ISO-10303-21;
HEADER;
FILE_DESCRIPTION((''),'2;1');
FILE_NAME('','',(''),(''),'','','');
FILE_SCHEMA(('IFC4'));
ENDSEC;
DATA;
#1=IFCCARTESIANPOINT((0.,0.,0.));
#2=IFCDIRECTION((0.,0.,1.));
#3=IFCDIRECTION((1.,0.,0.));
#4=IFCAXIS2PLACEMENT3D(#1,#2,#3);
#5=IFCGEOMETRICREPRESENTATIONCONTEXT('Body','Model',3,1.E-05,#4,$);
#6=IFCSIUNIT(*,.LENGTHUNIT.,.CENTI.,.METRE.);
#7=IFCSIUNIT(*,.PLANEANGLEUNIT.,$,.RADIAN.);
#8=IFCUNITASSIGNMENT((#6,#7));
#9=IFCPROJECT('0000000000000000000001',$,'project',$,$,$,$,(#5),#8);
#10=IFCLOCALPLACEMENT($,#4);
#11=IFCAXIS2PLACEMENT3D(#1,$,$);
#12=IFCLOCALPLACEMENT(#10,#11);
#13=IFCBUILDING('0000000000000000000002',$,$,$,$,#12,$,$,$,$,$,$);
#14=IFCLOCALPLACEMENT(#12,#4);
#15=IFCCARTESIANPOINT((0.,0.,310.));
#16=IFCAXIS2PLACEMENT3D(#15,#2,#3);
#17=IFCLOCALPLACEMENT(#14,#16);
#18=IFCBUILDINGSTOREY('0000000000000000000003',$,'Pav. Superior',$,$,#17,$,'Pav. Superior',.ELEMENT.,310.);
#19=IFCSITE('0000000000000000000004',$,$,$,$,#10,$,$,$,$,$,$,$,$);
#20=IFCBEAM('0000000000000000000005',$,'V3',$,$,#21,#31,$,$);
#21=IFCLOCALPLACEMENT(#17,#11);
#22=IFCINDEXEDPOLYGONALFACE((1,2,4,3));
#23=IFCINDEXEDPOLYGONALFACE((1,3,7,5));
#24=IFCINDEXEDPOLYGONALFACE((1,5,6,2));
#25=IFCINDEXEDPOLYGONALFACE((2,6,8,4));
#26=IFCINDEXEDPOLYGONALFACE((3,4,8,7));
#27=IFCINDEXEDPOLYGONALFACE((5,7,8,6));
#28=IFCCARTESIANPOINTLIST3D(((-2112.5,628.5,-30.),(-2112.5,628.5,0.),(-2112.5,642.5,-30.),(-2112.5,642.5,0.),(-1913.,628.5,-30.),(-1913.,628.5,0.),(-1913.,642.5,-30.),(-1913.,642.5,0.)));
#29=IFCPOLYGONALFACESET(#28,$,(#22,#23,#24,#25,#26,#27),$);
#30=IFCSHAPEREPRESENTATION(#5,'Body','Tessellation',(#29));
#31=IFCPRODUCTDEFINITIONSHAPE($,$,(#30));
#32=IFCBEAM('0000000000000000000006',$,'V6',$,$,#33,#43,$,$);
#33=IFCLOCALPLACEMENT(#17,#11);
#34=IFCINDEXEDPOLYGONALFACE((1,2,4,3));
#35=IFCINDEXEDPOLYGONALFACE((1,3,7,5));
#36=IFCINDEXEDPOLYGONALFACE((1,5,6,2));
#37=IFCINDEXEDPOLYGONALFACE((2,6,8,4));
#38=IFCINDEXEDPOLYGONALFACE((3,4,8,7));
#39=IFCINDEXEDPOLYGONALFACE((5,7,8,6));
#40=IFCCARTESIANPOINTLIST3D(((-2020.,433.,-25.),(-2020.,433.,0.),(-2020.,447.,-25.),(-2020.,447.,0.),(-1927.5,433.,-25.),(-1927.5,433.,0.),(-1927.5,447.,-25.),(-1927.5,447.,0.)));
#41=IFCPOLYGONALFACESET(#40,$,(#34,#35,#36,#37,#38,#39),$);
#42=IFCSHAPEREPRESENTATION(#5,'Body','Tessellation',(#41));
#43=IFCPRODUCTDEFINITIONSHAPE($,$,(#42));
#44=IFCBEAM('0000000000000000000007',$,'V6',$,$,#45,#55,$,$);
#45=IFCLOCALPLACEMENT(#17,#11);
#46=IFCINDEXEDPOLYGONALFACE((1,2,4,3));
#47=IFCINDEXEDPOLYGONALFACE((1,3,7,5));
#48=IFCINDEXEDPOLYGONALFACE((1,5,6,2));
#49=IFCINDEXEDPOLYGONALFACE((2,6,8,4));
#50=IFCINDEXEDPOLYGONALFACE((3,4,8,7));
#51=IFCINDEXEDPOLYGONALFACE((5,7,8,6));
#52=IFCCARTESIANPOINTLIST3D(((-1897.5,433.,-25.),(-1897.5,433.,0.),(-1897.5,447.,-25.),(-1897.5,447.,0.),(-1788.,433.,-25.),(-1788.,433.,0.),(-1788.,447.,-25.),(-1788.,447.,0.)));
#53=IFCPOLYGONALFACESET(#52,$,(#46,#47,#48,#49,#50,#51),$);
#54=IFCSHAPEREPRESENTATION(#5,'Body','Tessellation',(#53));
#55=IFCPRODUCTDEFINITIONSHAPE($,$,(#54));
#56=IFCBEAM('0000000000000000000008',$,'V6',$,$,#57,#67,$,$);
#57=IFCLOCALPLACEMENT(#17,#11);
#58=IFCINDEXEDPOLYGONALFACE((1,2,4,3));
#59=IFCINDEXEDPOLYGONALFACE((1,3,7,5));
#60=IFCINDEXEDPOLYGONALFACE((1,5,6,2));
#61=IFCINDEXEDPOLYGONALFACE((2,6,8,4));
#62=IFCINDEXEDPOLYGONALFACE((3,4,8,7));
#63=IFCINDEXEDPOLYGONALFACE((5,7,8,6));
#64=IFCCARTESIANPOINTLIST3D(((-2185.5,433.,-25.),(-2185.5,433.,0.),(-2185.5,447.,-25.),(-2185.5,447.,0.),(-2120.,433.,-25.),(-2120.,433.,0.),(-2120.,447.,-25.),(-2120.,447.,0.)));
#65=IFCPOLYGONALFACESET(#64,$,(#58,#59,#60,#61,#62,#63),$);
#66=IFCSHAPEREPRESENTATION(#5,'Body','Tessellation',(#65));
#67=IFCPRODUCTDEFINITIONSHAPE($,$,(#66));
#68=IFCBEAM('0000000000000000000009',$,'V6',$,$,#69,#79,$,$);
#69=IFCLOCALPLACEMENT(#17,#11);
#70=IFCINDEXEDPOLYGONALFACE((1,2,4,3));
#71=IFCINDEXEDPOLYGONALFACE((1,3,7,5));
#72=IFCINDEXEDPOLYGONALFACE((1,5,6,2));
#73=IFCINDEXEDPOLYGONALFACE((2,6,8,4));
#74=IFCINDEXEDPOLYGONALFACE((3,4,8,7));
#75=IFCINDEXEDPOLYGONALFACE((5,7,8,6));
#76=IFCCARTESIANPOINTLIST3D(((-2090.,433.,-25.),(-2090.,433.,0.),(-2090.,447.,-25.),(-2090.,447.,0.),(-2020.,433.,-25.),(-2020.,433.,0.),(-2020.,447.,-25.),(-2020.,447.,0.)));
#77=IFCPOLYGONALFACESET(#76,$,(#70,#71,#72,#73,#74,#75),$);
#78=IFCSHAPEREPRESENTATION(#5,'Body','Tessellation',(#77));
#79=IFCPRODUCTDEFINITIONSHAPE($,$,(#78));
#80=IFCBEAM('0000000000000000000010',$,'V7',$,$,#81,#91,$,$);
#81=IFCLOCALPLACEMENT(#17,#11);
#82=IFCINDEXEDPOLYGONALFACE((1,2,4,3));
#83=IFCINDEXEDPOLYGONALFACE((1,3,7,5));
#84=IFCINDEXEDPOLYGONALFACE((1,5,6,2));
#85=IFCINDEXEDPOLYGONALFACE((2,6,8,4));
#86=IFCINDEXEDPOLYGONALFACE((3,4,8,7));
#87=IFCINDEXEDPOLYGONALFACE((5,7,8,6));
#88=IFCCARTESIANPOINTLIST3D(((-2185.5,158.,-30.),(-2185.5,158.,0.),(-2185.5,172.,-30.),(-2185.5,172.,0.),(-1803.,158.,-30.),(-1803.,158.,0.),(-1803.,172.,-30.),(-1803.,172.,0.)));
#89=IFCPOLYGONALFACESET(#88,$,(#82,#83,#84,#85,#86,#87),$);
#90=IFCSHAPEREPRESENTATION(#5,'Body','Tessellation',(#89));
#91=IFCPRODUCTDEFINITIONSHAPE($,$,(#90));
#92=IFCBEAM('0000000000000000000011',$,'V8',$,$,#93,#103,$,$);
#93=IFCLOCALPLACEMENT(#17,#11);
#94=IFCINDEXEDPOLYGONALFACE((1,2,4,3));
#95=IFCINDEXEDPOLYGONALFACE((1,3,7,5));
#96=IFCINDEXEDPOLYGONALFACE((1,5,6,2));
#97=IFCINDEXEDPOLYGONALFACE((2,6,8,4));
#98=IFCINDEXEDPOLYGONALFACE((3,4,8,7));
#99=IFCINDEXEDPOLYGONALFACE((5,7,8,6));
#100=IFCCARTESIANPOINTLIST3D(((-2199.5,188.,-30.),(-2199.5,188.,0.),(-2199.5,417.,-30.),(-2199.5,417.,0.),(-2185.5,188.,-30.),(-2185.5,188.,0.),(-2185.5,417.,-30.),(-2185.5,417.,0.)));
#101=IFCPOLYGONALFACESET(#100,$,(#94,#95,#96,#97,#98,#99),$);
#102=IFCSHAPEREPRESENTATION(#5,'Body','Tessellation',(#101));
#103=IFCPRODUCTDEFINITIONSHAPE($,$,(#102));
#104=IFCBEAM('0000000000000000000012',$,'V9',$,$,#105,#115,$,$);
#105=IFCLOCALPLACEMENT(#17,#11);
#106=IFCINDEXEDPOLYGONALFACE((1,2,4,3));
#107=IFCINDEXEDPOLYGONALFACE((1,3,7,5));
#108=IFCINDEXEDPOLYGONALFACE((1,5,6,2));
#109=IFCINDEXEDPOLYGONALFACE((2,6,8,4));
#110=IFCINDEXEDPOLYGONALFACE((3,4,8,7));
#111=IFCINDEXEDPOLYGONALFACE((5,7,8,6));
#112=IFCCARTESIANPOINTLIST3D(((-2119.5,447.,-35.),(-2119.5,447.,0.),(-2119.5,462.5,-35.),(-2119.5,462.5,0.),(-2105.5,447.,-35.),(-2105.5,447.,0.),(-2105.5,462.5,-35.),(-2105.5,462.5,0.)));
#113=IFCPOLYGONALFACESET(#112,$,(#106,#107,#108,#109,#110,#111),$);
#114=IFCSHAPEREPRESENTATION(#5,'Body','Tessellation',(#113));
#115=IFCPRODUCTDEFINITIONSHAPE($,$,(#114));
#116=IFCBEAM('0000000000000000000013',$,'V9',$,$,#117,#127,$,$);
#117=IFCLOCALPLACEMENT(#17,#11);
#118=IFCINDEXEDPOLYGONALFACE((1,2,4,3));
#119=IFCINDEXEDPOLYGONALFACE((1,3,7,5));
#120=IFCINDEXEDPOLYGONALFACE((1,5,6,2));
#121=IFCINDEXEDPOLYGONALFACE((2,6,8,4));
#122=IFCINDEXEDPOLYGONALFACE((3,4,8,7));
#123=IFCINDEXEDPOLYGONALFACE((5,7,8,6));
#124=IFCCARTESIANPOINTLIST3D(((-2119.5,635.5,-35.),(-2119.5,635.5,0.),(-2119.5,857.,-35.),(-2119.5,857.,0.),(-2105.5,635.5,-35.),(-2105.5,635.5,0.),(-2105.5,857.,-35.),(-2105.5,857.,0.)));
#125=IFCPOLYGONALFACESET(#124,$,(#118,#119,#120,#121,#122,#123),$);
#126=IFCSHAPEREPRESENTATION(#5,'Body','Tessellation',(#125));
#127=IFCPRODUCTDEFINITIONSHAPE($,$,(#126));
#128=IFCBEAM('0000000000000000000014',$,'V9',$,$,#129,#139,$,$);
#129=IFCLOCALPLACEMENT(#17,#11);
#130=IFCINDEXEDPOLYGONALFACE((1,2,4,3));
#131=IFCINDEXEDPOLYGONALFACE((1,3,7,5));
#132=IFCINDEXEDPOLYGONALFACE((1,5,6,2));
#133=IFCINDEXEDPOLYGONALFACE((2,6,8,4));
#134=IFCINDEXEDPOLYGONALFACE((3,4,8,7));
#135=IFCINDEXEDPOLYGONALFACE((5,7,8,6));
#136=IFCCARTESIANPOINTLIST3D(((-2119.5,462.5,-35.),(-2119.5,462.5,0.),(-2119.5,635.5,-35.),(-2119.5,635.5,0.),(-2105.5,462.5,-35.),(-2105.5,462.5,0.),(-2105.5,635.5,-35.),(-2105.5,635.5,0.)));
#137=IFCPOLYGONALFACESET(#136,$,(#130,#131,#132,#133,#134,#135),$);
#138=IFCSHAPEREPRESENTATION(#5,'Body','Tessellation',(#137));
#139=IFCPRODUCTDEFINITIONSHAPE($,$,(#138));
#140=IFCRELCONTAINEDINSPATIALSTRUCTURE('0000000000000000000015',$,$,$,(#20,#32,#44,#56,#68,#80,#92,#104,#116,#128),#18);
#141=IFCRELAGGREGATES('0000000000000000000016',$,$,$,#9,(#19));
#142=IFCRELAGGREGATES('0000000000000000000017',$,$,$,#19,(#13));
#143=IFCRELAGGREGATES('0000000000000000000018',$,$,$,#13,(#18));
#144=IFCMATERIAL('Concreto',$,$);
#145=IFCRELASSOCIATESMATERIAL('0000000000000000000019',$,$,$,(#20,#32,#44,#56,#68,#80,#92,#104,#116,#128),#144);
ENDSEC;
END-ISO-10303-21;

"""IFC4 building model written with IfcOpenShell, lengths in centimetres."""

from ifc_helpers import new_model, si_unit, frame, origin, origin_with_axes, origin_2d_with_axis, place, context, project, spatial, rectangle, extrude, material, element, save


model = new_model("IFC4")

# Units and contexts
model_context = context("Model", 3, precision=1e-05, world=origin_with_axes(), identifier="Body")
ifc_project = project(units=[si_unit("LENGTHUNIT", "METRE", prefix="CENTI"), si_unit("PLANEANGLEUNIT", "RADIAN")], contexts=[model_context])

# Site, building, storey
site_placement = place(None, origin_with_axes())
site = spatial("IfcSite", under=ifc_project, at=site_placement)
building_placement = place(site_placement, origin())
building = spatial("IfcBuilding", under=site, at=building_placement)
placement = place(building_placement, origin_with_axes())
storey_placement = place(placement, frame((0.0, 0.0, 310.0), z_axis=(0.0, 0.0, 1.0), x_axis=(1.0, 0.0, 0.0)))
storey = spatial("IfcBuildingStorey", under=building, at=storey_placement, Name="Pav. Superior", LongName="Pav. Superior", CompositionType="ELEMENT", Elevation=310.0)

# Shared definitions
ifc_material = material(Name="Concreto")

# Beams
beam_1_placement = place(storey_placement, frame((-2012.75, 635.5, 0.0), z_axis=(0.0, 0.0, 1.0), x_axis=(1.0, 0.0, 0.0)))
element("IfcBeam", 1, at=beam_1_placement, inside=storey, material=ifc_material, Name="V3", context=model_context, shape_type="SolidModel", body=[
    extrude(rectangle(XDim=14.0, YDim=30.0, at=origin_2d_with_axis()), frame((-99.75, 0.0, -15.0), z_axis=(1.0, 0.0, 0.0), x_axis=(0.0, -1.0, 0.0)), (0.0, 0.0, 1.0), 199.5),
])
beam_2_placement = place(storey_placement, frame((-1973.75, 440.0, 0.0), z_axis=(0.0, 0.0, 1.0), x_axis=(1.0, 0.0, 0.0)))
element("IfcBeam", 2, at=beam_2_placement, inside=storey, material=ifc_material, Name="V6", context=model_context, shape_type="SolidModel", body=[
    extrude(rectangle(XDim=14.0, YDim=25.0, at=origin_2d_with_axis()), frame((-46.25, 0.0, -12.5), z_axis=(1.0, 0.0, 0.0), x_axis=(0.0, -1.0, 0.0)), (0.0, 0.0, 1.0), 92.5),
])
beam_3_placement = place(storey_placement, frame((-1842.75, 440.0, 0.0), z_axis=(0.0, 0.0, 1.0), x_axis=(1.0, 0.0, 0.0)))
element("IfcBeam", 3, at=beam_3_placement, inside=storey, material=ifc_material, Name="V6", context=model_context, shape_type="SolidModel", body=[
    extrude(rectangle(XDim=14.0, YDim=25.0, at=origin_2d_with_axis()), frame((-54.75, 0.0, -12.5), z_axis=(1.0, 0.0, 0.0), x_axis=(0.0, -1.0, 0.0)), (0.0, 0.0, 1.0), 109.5),
])
beam_4_placement = place(storey_placement, frame((-2152.75, 440.0, 0.0), z_axis=(0.0, 0.0, 1.0), x_axis=(1.0, 0.0, 0.0)))
element("IfcBeam", 4, at=beam_4_placement, inside=storey, material=ifc_material, Name="V6", context=model_context, shape_type="SolidModel", body=[
    extrude(rectangle(XDim=14.0, YDim=25.0, at=origin_2d_with_axis()), frame((-32.75, 0.0, -12.5), z_axis=(1.0, 0.0, 0.0), x_axis=(0.0, -1.0, 0.0)), (0.0, 0.0, 1.0), 65.5),
])
beam_5_placement = place(storey_placement, frame((-2055.0, 440.0, 0.0), z_axis=(0.0, 0.0, 1.0), x_axis=(1.0, 0.0, 0.0)))
element("IfcBeam", 5, at=beam_5_placement, inside=storey, material=ifc_material, Name="V6", context=model_context, shape_type="SolidModel", body=[
    extrude(rectangle(XDim=14.0, YDim=25.0, at=origin_2d_with_axis()), frame((-35.0, 0.0, -12.5), z_axis=(1.0, 0.0, 0.0), x_axis=(0.0, -1.0, 0.0)), (0.0, 0.0, 1.0), 70.0),
])
beam_6_placement = place(storey_placement, frame((-1994.25, 165.0, 0.0), z_axis=(0.0, 0.0, 1.0), x_axis=(1.0, 0.0, 0.0)))
element("IfcBeam", 6, at=beam_6_placement, inside=storey, material=ifc_material, Name="V7", context=model_context, shape_type="SolidModel", body=[
    extrude(rectangle(XDim=14.0, YDim=30.0, at=origin_2d_with_axis()), frame((-191.25, 0.0, -15.0), z_axis=(1.0, 0.0, 0.0), x_axis=(0.0, -1.0, 0.0)), (0.0, 0.0, 1.0), 382.5),
])
beam_7_placement = place(storey_placement, frame((-2192.5, 302.5, 0.0), z_axis=(0.0, 0.0, 1.0), x_axis=(1.0, 0.0, 0.0)))
element("IfcBeam", 7, at=beam_7_placement, inside=storey, material=ifc_material, Name="V8", context=model_context, shape_type="SolidModel", body=[
    extrude(rectangle(XDim=14.0, YDim=30.0, at=origin_2d_with_axis()), frame((0.0, -114.5, -15.0), z_axis=(0.0, 1.0, 0.0), x_axis=(-1.0, 0.0, 0.0)), (0.0, 0.0, 1.0), 229.0),
])
beam_8_placement = place(storey_placement, frame((-2112.5, 454.75, 0.0), z_axis=(0.0, 0.0, 1.0), x_axis=(1.0, 0.0, 0.0)))
element("IfcBeam", 8, at=beam_8_placement, inside=storey, material=ifc_material, Name="V9", context=model_context, shape_type="SolidModel", body=[
    extrude(rectangle(XDim=14.0, YDim=35.0, at=origin_2d_with_axis()), frame((0.0, -7.75, -17.5), z_axis=(0.0, 1.0, 0.0), x_axis=(-1.0, 0.0, 0.0)), (0.0, 0.0, 1.0), 15.5),
])
beam_9_placement = place(storey_placement, frame((-2112.5, 746.25, 0.0), z_axis=(0.0, 0.0, 1.0), x_axis=(1.0, 0.0, 0.0)))
element("IfcBeam", 9, at=beam_9_placement, inside=storey, material=ifc_material, Name="V9", context=model_context, shape_type="SolidModel", body=[
    extrude(rectangle(XDim=14.0, YDim=35.0, at=origin_2d_with_axis()), frame((0.0, -110.75, -17.5), z_axis=(0.0, 1.0, 0.0), x_axis=(-1.0, 0.0, 0.0)), (0.0, 0.0, 1.0), 221.5),
])
beam_10_placement = place(storey_placement, frame((-2112.5, 549.0, 0.0), z_axis=(0.0, 0.0, 1.0), x_axis=(1.0, 0.0, 0.0)))
element("IfcBeam", 10, at=beam_10_placement, inside=storey, material=ifc_material, Name="V9", context=model_context, shape_type="SolidModel", body=[
    extrude(rectangle(XDim=14.0, YDim=35.0, at=origin_2d_with_axis()), frame((0.0, -86.5, -17.5), z_axis=(0.0, 1.0, 0.0), x_axis=(-1.0, 0.0, 0.0)), (0.0, 0.0, 1.0), 173.0),
])

save(model, "model.ifc")
